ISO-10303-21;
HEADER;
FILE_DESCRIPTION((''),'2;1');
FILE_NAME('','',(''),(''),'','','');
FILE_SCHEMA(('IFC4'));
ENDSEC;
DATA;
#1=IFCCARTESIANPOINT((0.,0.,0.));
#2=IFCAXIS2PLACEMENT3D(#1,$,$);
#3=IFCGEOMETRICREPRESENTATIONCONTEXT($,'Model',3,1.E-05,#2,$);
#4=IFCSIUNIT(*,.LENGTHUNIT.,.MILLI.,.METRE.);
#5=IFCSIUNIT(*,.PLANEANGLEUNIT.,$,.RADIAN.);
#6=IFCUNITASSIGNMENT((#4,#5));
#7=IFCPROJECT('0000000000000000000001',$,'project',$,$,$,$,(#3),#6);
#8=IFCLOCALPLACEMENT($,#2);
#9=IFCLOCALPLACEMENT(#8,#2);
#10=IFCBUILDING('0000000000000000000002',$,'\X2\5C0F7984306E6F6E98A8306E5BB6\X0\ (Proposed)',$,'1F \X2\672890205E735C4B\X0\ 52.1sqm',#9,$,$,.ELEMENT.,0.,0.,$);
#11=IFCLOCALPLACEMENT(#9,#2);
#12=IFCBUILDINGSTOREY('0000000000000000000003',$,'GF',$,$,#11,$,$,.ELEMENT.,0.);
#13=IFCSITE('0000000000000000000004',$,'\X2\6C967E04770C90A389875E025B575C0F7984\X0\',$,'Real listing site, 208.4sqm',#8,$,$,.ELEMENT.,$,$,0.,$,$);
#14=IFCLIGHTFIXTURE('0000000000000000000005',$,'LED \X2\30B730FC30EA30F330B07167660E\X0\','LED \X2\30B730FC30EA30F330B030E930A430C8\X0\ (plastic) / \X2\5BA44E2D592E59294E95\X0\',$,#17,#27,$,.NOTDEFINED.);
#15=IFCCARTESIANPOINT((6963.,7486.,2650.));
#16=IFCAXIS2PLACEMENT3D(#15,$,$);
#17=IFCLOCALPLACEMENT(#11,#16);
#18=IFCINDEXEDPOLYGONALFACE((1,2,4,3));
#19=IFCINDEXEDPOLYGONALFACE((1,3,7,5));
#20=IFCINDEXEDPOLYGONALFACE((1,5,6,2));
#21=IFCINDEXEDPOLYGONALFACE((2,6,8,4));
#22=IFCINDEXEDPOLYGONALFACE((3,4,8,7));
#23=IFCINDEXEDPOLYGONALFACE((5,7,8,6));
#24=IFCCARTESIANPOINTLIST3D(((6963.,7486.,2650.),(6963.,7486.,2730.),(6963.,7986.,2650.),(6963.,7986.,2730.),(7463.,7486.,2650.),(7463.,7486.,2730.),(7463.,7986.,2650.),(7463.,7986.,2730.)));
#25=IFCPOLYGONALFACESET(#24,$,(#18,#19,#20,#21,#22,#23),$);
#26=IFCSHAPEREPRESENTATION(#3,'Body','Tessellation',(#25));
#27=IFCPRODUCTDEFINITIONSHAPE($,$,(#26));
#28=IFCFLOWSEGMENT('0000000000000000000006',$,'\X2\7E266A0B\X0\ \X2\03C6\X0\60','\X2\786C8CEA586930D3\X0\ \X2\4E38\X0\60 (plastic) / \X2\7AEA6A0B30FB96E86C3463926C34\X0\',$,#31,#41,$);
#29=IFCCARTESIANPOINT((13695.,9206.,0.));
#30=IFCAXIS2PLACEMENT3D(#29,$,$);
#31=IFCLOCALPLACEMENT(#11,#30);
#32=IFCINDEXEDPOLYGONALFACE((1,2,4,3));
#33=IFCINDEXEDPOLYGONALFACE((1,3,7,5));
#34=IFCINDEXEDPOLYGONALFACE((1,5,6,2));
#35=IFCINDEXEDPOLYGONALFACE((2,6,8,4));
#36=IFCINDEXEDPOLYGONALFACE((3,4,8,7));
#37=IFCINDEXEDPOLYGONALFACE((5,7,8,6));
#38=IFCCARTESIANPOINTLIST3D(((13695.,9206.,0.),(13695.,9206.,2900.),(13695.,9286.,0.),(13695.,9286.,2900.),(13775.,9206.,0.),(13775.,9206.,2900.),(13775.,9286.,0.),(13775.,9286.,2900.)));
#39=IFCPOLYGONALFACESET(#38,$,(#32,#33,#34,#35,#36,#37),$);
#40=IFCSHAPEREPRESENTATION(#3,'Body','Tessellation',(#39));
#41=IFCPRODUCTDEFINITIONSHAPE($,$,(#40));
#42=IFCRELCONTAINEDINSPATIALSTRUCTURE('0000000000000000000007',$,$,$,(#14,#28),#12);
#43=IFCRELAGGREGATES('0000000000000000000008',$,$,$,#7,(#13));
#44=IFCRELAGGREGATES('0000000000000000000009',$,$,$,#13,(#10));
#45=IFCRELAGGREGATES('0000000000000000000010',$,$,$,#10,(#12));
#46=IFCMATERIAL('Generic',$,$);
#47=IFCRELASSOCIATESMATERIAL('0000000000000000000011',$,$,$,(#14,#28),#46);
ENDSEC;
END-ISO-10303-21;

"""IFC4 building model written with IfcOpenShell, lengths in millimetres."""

from ifc_helpers import new_model, si_unit, frame, frame_2d, origin, place, context, project, spatial, rectangle, extrude, material, element, save


model = new_model("IFC4")

# Units and contexts
model_context = context("Model", 3, precision=1e-05, world=origin())
ifc_project = project(units=[si_unit("LENGTHUNIT", "METRE", prefix="MILLI"), si_unit("PLANEANGLEUNIT", "RADIAN")], contexts=[model_context])

# Site, building, storey
site_placement = place(None, origin())
site = spatial("IfcSite", under=ifc_project, at=site_placement, Name="沖縄県那覇市字小禄", ObjectType="Real listing site, 208.4sqm", CompositionType="ELEMENT", RefElevation=0.0)
building_placement = place(site_placement, origin())
building = spatial("IfcBuilding", under=site, at=building_placement, Name="小禄の潮風の家 (Proposed)", ObjectType="1F 木造平屋 52.1sqm", CompositionType="ELEMENT", ElevationOfRefHeight=0.0, ElevationOfTerrain=0.0)
storey_placement = place(building_placement, origin())
storey = spatial("IfcBuildingStorey", under=building, at=storey_placement, Name="GF", CompositionType="ELEMENT", Elevation=0.0)

# Shared definitions
ifc_material_1 = material(Name="Generic")

# Light fixture
light_fixture_1_placement = place(storey_placement, frame((6963.0, 7486.0, 2650.0)))
element("IfcLightFixture", 1, at=light_fixture_1_placement, inside=storey, material=ifc_material_1, Name="LED シーリング照明", Description="LED シーリングライト (plastic) / 室中央天井", PredefinedType="NOTDEFINED", context=model_context, shape_type="SweptSolid", body=[
    extrude(rectangle(XDim=500.0, YDim=500.0, at=frame_2d((250.0, 250.0))), frame((6963.0, 7486.0, 2650.0)), (0.0, 0.0, 1.0), 80.0),
])

# Flow segment
flow_segment_placement = place(storey_placement, frame((13695.0, 9206.0, 0.0)))
element("IfcFlowSegment", 2, at=flow_segment_placement, inside=storey, material=ifc_material_1, Name="縦樋 φ60", Description="硬質塩ビ 丸60 (plastic) / 竪樋・雨水排水", context=model_context, shape_type="SweptSolid", body=[
    extrude(rectangle(XDim=80.0, YDim=80.0, at=frame_2d((40.0, 40.0))), frame((13695.0, 9206.0, 0.0)), (0.0, 0.0, 1.0), 2900.0),
])

save(model, "model.ifc")
